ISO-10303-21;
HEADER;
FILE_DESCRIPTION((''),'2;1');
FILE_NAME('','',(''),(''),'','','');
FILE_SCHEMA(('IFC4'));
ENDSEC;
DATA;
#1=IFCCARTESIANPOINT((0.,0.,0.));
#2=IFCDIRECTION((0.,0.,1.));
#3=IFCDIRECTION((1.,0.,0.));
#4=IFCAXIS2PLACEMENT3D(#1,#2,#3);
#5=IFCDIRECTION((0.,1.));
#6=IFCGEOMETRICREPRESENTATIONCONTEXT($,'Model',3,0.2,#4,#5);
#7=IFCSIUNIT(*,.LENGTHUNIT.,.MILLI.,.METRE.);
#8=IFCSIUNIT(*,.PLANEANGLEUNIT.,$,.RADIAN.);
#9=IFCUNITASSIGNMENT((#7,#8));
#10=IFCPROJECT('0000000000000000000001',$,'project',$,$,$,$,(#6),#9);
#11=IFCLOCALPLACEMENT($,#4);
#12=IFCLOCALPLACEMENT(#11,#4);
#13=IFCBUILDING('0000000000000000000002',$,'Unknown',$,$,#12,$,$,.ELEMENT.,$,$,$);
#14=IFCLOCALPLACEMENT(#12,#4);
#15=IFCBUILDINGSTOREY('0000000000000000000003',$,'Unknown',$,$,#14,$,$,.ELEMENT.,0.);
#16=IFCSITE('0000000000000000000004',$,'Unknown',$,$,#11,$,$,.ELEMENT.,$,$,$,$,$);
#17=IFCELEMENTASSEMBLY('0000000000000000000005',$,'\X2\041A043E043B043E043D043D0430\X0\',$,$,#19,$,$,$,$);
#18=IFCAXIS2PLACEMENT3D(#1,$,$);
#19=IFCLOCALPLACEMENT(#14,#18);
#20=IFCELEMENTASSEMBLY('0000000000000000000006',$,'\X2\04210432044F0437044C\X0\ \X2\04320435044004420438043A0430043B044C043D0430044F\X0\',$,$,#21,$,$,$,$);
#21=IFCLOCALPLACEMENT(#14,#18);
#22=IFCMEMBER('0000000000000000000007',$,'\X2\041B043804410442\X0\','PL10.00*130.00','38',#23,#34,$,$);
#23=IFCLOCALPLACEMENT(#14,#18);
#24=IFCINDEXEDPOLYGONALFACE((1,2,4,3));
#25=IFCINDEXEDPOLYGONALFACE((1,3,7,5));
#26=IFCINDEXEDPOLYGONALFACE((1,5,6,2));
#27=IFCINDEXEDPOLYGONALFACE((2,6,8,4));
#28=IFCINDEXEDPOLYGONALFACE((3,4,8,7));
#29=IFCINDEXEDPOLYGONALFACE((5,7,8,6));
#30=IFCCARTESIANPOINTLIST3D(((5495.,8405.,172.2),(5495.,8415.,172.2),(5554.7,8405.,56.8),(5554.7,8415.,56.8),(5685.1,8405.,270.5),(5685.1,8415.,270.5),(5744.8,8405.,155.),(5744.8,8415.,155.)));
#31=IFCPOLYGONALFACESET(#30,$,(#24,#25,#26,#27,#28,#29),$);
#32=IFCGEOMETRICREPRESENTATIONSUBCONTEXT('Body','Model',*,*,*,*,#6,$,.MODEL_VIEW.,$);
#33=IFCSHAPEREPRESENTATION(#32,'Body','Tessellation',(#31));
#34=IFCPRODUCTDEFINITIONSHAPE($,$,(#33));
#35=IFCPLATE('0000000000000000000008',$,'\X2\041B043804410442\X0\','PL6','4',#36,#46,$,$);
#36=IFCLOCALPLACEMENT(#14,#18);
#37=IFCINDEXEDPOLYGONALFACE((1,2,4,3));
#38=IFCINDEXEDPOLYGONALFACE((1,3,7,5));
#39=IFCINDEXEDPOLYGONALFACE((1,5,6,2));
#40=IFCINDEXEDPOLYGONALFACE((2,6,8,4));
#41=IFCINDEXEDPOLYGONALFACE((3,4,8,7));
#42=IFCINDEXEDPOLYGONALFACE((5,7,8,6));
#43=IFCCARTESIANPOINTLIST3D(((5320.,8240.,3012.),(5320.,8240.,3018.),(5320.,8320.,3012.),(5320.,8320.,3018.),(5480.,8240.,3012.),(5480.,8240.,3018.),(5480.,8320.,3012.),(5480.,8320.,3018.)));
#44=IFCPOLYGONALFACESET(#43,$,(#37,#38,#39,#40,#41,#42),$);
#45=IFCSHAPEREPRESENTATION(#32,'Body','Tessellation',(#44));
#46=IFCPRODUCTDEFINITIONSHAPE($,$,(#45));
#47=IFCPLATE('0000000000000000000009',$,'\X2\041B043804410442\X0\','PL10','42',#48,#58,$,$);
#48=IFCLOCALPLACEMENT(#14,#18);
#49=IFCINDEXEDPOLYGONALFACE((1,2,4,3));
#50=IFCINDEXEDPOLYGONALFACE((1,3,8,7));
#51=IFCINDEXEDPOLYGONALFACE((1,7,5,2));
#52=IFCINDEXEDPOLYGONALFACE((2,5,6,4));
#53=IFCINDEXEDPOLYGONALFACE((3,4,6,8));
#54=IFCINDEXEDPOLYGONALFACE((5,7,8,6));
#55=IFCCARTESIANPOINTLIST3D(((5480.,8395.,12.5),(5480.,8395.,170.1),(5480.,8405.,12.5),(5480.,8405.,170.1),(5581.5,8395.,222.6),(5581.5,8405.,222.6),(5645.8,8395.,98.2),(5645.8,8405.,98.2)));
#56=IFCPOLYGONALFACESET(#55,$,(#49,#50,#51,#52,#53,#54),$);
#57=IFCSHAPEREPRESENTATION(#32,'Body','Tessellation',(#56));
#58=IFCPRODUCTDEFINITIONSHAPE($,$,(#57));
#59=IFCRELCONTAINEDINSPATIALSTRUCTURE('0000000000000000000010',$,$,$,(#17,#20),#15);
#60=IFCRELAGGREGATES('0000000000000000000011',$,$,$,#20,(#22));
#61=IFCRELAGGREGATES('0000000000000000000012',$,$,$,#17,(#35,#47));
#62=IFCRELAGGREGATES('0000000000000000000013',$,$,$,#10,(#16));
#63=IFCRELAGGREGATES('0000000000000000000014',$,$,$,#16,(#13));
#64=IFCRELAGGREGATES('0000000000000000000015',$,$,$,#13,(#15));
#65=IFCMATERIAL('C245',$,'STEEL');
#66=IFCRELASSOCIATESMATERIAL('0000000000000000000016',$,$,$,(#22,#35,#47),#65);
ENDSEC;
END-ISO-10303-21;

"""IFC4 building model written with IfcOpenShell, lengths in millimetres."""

from ifc_helpers import new_model, si_unit, direction, frame, origin_with_axes, place, context, subcontext, project, spatial, line, indexed_curve, outline, extrude, material, element, aggregate, save


model = new_model("IFC4")

# Units and contexts
model_context = context("Model", 3, precision=0.2, world=origin_with_axes(), true_north=direction((0.0, 1.0)))
body_context = subcontext(model_context, "Body", "Model", "MODEL_VIEW")
ifc_project = project(units=[si_unit("LENGTHUNIT", "METRE", prefix="MILLI"), si_unit("PLANEANGLEUNIT", "RADIAN")], contexts=[model_context])

# Site, building, storey
site_placement = place(None, origin_with_axes())
site = spatial("IfcSite", under=ifc_project, at=site_placement, Name="Unknown", CompositionType="ELEMENT")
building_placement = place(site_placement, origin_with_axes())
building = spatial("IfcBuilding", under=site, at=building_placement, Name="Unknown", CompositionType="ELEMENT")
storey_placement = place(building_placement, origin_with_axes())
storey = spatial("IfcBuildingStorey", under=building, at=storey_placement, Name="Unknown", CompositionType="ELEMENT", Elevation=0.0)

# Shared definitions
ifc_material_1 = material(Name="C245", Category="STEEL")

# Element assembly
assembly_1_placement = place(storey_placement, frame((5400.0, 8400.0, -40.0), z_axis=(-1.0, 0.0, 0.0), x_axis=(0.0, 0.0, 1.0)))
assembly_1 = element("IfcElementAssembly", 1, at=assembly_1_placement, inside=storey, Name="Колонна")

# Element assembly, member
assembly_2_placement = place(storey_placement, frame((5400.0, 8410.0, 50.0), z_axis=(0.0, -1.0, 0.0), x_axis=(0.888426, 0.0, 0.45902)))
assembly_2 = element("IfcElementAssembly", 2, at=assembly_2_placement, inside=storey, Name="Связь вертикальная")
member_1_placement = place(assembly_2_placement, frame((140.5, 0.0, 0.0), z_axis=(0.0, 0.0, 1.0), x_axis=(1.0, 0.0, 0.0)))
member_1 = element("IfcMember", 3, at=member_1_placement, material=ifc_material_1, Name="Лист", Description="PL10.00*130.00", ObjectType="38", context=body_context, shape_type="SolidModel", body=[
    extrude(outline(indexed_curve([(-5.0, -65.0), (5.0, -65.0), (5.0, 65.0), (-5.0, 65.0)], segments=[line(1, 2, 3, 4, 1)])), frame((0.0, 0.0, 0.0), z_axis=(-1.0, 0.0, 0.0), x_axis=(0.0, 0.0, 1.0)), (0.0, 0.0, -1.0), 214.0),
])
aggregate(assembly_2, [member_1])

# Plates
plate_1_placement = place(assembly_1_placement, frame((3055.0, -80.0, -80.0), z_axis=(1.0, 0.0, 0.0), x_axis=(0.0, 0.0, 1.0)))
plate_1 = element("IfcPlate", 4, at=plate_1_placement, material=ifc_material_1, Name="Лист", Description="PL6", ObjectType="4", context=body_context, shape_type="SolidModel", body=[
    extrude(outline(indexed_curve([(0.0, 0.0), (160.0, 0.0), (160.0, 80.0), (0.0, 80.0)], segments=[line(1, 2, 3, 4, 1)])), frame((0.0, 0.0, 3.0), z_axis=(0.0, 0.0, 1.0), x_axis=(1.0, 0.0, 0.0)), (0.0, 0.0, -1.0), 6.0),
])
plate_2_placement = place(assembly_1_placement, frame((52.5, 0.0, -80.0), z_axis=(0.0, -1.0, 0.0), x_axis=(0.45902, 0.0, -0.888426)))
plate_2 = element("IfcPlate", 5, at=plate_2_placement, material=ifc_material_1, Name="Лист", Description="PL10", ObjectType="42", context=body_context, shape_type="SolidModel", body=[
    extrude(outline(indexed_curve([(0.0, 0.0), (186.6, 0.0), (186.6, 140.0), (72.3, 140.0)], segments=[line(1, 2, 3, 4, 1)])), frame((0.0, 0.0, 5.0), z_axis=(0.0, 0.0, 1.0), x_axis=(1.0, 0.0, 0.0)), (0.0, 0.0, -1.0), 10.0),
])

aggregate(assembly_1, [plate_1, plate_2])

save(model, "model.ifc")
